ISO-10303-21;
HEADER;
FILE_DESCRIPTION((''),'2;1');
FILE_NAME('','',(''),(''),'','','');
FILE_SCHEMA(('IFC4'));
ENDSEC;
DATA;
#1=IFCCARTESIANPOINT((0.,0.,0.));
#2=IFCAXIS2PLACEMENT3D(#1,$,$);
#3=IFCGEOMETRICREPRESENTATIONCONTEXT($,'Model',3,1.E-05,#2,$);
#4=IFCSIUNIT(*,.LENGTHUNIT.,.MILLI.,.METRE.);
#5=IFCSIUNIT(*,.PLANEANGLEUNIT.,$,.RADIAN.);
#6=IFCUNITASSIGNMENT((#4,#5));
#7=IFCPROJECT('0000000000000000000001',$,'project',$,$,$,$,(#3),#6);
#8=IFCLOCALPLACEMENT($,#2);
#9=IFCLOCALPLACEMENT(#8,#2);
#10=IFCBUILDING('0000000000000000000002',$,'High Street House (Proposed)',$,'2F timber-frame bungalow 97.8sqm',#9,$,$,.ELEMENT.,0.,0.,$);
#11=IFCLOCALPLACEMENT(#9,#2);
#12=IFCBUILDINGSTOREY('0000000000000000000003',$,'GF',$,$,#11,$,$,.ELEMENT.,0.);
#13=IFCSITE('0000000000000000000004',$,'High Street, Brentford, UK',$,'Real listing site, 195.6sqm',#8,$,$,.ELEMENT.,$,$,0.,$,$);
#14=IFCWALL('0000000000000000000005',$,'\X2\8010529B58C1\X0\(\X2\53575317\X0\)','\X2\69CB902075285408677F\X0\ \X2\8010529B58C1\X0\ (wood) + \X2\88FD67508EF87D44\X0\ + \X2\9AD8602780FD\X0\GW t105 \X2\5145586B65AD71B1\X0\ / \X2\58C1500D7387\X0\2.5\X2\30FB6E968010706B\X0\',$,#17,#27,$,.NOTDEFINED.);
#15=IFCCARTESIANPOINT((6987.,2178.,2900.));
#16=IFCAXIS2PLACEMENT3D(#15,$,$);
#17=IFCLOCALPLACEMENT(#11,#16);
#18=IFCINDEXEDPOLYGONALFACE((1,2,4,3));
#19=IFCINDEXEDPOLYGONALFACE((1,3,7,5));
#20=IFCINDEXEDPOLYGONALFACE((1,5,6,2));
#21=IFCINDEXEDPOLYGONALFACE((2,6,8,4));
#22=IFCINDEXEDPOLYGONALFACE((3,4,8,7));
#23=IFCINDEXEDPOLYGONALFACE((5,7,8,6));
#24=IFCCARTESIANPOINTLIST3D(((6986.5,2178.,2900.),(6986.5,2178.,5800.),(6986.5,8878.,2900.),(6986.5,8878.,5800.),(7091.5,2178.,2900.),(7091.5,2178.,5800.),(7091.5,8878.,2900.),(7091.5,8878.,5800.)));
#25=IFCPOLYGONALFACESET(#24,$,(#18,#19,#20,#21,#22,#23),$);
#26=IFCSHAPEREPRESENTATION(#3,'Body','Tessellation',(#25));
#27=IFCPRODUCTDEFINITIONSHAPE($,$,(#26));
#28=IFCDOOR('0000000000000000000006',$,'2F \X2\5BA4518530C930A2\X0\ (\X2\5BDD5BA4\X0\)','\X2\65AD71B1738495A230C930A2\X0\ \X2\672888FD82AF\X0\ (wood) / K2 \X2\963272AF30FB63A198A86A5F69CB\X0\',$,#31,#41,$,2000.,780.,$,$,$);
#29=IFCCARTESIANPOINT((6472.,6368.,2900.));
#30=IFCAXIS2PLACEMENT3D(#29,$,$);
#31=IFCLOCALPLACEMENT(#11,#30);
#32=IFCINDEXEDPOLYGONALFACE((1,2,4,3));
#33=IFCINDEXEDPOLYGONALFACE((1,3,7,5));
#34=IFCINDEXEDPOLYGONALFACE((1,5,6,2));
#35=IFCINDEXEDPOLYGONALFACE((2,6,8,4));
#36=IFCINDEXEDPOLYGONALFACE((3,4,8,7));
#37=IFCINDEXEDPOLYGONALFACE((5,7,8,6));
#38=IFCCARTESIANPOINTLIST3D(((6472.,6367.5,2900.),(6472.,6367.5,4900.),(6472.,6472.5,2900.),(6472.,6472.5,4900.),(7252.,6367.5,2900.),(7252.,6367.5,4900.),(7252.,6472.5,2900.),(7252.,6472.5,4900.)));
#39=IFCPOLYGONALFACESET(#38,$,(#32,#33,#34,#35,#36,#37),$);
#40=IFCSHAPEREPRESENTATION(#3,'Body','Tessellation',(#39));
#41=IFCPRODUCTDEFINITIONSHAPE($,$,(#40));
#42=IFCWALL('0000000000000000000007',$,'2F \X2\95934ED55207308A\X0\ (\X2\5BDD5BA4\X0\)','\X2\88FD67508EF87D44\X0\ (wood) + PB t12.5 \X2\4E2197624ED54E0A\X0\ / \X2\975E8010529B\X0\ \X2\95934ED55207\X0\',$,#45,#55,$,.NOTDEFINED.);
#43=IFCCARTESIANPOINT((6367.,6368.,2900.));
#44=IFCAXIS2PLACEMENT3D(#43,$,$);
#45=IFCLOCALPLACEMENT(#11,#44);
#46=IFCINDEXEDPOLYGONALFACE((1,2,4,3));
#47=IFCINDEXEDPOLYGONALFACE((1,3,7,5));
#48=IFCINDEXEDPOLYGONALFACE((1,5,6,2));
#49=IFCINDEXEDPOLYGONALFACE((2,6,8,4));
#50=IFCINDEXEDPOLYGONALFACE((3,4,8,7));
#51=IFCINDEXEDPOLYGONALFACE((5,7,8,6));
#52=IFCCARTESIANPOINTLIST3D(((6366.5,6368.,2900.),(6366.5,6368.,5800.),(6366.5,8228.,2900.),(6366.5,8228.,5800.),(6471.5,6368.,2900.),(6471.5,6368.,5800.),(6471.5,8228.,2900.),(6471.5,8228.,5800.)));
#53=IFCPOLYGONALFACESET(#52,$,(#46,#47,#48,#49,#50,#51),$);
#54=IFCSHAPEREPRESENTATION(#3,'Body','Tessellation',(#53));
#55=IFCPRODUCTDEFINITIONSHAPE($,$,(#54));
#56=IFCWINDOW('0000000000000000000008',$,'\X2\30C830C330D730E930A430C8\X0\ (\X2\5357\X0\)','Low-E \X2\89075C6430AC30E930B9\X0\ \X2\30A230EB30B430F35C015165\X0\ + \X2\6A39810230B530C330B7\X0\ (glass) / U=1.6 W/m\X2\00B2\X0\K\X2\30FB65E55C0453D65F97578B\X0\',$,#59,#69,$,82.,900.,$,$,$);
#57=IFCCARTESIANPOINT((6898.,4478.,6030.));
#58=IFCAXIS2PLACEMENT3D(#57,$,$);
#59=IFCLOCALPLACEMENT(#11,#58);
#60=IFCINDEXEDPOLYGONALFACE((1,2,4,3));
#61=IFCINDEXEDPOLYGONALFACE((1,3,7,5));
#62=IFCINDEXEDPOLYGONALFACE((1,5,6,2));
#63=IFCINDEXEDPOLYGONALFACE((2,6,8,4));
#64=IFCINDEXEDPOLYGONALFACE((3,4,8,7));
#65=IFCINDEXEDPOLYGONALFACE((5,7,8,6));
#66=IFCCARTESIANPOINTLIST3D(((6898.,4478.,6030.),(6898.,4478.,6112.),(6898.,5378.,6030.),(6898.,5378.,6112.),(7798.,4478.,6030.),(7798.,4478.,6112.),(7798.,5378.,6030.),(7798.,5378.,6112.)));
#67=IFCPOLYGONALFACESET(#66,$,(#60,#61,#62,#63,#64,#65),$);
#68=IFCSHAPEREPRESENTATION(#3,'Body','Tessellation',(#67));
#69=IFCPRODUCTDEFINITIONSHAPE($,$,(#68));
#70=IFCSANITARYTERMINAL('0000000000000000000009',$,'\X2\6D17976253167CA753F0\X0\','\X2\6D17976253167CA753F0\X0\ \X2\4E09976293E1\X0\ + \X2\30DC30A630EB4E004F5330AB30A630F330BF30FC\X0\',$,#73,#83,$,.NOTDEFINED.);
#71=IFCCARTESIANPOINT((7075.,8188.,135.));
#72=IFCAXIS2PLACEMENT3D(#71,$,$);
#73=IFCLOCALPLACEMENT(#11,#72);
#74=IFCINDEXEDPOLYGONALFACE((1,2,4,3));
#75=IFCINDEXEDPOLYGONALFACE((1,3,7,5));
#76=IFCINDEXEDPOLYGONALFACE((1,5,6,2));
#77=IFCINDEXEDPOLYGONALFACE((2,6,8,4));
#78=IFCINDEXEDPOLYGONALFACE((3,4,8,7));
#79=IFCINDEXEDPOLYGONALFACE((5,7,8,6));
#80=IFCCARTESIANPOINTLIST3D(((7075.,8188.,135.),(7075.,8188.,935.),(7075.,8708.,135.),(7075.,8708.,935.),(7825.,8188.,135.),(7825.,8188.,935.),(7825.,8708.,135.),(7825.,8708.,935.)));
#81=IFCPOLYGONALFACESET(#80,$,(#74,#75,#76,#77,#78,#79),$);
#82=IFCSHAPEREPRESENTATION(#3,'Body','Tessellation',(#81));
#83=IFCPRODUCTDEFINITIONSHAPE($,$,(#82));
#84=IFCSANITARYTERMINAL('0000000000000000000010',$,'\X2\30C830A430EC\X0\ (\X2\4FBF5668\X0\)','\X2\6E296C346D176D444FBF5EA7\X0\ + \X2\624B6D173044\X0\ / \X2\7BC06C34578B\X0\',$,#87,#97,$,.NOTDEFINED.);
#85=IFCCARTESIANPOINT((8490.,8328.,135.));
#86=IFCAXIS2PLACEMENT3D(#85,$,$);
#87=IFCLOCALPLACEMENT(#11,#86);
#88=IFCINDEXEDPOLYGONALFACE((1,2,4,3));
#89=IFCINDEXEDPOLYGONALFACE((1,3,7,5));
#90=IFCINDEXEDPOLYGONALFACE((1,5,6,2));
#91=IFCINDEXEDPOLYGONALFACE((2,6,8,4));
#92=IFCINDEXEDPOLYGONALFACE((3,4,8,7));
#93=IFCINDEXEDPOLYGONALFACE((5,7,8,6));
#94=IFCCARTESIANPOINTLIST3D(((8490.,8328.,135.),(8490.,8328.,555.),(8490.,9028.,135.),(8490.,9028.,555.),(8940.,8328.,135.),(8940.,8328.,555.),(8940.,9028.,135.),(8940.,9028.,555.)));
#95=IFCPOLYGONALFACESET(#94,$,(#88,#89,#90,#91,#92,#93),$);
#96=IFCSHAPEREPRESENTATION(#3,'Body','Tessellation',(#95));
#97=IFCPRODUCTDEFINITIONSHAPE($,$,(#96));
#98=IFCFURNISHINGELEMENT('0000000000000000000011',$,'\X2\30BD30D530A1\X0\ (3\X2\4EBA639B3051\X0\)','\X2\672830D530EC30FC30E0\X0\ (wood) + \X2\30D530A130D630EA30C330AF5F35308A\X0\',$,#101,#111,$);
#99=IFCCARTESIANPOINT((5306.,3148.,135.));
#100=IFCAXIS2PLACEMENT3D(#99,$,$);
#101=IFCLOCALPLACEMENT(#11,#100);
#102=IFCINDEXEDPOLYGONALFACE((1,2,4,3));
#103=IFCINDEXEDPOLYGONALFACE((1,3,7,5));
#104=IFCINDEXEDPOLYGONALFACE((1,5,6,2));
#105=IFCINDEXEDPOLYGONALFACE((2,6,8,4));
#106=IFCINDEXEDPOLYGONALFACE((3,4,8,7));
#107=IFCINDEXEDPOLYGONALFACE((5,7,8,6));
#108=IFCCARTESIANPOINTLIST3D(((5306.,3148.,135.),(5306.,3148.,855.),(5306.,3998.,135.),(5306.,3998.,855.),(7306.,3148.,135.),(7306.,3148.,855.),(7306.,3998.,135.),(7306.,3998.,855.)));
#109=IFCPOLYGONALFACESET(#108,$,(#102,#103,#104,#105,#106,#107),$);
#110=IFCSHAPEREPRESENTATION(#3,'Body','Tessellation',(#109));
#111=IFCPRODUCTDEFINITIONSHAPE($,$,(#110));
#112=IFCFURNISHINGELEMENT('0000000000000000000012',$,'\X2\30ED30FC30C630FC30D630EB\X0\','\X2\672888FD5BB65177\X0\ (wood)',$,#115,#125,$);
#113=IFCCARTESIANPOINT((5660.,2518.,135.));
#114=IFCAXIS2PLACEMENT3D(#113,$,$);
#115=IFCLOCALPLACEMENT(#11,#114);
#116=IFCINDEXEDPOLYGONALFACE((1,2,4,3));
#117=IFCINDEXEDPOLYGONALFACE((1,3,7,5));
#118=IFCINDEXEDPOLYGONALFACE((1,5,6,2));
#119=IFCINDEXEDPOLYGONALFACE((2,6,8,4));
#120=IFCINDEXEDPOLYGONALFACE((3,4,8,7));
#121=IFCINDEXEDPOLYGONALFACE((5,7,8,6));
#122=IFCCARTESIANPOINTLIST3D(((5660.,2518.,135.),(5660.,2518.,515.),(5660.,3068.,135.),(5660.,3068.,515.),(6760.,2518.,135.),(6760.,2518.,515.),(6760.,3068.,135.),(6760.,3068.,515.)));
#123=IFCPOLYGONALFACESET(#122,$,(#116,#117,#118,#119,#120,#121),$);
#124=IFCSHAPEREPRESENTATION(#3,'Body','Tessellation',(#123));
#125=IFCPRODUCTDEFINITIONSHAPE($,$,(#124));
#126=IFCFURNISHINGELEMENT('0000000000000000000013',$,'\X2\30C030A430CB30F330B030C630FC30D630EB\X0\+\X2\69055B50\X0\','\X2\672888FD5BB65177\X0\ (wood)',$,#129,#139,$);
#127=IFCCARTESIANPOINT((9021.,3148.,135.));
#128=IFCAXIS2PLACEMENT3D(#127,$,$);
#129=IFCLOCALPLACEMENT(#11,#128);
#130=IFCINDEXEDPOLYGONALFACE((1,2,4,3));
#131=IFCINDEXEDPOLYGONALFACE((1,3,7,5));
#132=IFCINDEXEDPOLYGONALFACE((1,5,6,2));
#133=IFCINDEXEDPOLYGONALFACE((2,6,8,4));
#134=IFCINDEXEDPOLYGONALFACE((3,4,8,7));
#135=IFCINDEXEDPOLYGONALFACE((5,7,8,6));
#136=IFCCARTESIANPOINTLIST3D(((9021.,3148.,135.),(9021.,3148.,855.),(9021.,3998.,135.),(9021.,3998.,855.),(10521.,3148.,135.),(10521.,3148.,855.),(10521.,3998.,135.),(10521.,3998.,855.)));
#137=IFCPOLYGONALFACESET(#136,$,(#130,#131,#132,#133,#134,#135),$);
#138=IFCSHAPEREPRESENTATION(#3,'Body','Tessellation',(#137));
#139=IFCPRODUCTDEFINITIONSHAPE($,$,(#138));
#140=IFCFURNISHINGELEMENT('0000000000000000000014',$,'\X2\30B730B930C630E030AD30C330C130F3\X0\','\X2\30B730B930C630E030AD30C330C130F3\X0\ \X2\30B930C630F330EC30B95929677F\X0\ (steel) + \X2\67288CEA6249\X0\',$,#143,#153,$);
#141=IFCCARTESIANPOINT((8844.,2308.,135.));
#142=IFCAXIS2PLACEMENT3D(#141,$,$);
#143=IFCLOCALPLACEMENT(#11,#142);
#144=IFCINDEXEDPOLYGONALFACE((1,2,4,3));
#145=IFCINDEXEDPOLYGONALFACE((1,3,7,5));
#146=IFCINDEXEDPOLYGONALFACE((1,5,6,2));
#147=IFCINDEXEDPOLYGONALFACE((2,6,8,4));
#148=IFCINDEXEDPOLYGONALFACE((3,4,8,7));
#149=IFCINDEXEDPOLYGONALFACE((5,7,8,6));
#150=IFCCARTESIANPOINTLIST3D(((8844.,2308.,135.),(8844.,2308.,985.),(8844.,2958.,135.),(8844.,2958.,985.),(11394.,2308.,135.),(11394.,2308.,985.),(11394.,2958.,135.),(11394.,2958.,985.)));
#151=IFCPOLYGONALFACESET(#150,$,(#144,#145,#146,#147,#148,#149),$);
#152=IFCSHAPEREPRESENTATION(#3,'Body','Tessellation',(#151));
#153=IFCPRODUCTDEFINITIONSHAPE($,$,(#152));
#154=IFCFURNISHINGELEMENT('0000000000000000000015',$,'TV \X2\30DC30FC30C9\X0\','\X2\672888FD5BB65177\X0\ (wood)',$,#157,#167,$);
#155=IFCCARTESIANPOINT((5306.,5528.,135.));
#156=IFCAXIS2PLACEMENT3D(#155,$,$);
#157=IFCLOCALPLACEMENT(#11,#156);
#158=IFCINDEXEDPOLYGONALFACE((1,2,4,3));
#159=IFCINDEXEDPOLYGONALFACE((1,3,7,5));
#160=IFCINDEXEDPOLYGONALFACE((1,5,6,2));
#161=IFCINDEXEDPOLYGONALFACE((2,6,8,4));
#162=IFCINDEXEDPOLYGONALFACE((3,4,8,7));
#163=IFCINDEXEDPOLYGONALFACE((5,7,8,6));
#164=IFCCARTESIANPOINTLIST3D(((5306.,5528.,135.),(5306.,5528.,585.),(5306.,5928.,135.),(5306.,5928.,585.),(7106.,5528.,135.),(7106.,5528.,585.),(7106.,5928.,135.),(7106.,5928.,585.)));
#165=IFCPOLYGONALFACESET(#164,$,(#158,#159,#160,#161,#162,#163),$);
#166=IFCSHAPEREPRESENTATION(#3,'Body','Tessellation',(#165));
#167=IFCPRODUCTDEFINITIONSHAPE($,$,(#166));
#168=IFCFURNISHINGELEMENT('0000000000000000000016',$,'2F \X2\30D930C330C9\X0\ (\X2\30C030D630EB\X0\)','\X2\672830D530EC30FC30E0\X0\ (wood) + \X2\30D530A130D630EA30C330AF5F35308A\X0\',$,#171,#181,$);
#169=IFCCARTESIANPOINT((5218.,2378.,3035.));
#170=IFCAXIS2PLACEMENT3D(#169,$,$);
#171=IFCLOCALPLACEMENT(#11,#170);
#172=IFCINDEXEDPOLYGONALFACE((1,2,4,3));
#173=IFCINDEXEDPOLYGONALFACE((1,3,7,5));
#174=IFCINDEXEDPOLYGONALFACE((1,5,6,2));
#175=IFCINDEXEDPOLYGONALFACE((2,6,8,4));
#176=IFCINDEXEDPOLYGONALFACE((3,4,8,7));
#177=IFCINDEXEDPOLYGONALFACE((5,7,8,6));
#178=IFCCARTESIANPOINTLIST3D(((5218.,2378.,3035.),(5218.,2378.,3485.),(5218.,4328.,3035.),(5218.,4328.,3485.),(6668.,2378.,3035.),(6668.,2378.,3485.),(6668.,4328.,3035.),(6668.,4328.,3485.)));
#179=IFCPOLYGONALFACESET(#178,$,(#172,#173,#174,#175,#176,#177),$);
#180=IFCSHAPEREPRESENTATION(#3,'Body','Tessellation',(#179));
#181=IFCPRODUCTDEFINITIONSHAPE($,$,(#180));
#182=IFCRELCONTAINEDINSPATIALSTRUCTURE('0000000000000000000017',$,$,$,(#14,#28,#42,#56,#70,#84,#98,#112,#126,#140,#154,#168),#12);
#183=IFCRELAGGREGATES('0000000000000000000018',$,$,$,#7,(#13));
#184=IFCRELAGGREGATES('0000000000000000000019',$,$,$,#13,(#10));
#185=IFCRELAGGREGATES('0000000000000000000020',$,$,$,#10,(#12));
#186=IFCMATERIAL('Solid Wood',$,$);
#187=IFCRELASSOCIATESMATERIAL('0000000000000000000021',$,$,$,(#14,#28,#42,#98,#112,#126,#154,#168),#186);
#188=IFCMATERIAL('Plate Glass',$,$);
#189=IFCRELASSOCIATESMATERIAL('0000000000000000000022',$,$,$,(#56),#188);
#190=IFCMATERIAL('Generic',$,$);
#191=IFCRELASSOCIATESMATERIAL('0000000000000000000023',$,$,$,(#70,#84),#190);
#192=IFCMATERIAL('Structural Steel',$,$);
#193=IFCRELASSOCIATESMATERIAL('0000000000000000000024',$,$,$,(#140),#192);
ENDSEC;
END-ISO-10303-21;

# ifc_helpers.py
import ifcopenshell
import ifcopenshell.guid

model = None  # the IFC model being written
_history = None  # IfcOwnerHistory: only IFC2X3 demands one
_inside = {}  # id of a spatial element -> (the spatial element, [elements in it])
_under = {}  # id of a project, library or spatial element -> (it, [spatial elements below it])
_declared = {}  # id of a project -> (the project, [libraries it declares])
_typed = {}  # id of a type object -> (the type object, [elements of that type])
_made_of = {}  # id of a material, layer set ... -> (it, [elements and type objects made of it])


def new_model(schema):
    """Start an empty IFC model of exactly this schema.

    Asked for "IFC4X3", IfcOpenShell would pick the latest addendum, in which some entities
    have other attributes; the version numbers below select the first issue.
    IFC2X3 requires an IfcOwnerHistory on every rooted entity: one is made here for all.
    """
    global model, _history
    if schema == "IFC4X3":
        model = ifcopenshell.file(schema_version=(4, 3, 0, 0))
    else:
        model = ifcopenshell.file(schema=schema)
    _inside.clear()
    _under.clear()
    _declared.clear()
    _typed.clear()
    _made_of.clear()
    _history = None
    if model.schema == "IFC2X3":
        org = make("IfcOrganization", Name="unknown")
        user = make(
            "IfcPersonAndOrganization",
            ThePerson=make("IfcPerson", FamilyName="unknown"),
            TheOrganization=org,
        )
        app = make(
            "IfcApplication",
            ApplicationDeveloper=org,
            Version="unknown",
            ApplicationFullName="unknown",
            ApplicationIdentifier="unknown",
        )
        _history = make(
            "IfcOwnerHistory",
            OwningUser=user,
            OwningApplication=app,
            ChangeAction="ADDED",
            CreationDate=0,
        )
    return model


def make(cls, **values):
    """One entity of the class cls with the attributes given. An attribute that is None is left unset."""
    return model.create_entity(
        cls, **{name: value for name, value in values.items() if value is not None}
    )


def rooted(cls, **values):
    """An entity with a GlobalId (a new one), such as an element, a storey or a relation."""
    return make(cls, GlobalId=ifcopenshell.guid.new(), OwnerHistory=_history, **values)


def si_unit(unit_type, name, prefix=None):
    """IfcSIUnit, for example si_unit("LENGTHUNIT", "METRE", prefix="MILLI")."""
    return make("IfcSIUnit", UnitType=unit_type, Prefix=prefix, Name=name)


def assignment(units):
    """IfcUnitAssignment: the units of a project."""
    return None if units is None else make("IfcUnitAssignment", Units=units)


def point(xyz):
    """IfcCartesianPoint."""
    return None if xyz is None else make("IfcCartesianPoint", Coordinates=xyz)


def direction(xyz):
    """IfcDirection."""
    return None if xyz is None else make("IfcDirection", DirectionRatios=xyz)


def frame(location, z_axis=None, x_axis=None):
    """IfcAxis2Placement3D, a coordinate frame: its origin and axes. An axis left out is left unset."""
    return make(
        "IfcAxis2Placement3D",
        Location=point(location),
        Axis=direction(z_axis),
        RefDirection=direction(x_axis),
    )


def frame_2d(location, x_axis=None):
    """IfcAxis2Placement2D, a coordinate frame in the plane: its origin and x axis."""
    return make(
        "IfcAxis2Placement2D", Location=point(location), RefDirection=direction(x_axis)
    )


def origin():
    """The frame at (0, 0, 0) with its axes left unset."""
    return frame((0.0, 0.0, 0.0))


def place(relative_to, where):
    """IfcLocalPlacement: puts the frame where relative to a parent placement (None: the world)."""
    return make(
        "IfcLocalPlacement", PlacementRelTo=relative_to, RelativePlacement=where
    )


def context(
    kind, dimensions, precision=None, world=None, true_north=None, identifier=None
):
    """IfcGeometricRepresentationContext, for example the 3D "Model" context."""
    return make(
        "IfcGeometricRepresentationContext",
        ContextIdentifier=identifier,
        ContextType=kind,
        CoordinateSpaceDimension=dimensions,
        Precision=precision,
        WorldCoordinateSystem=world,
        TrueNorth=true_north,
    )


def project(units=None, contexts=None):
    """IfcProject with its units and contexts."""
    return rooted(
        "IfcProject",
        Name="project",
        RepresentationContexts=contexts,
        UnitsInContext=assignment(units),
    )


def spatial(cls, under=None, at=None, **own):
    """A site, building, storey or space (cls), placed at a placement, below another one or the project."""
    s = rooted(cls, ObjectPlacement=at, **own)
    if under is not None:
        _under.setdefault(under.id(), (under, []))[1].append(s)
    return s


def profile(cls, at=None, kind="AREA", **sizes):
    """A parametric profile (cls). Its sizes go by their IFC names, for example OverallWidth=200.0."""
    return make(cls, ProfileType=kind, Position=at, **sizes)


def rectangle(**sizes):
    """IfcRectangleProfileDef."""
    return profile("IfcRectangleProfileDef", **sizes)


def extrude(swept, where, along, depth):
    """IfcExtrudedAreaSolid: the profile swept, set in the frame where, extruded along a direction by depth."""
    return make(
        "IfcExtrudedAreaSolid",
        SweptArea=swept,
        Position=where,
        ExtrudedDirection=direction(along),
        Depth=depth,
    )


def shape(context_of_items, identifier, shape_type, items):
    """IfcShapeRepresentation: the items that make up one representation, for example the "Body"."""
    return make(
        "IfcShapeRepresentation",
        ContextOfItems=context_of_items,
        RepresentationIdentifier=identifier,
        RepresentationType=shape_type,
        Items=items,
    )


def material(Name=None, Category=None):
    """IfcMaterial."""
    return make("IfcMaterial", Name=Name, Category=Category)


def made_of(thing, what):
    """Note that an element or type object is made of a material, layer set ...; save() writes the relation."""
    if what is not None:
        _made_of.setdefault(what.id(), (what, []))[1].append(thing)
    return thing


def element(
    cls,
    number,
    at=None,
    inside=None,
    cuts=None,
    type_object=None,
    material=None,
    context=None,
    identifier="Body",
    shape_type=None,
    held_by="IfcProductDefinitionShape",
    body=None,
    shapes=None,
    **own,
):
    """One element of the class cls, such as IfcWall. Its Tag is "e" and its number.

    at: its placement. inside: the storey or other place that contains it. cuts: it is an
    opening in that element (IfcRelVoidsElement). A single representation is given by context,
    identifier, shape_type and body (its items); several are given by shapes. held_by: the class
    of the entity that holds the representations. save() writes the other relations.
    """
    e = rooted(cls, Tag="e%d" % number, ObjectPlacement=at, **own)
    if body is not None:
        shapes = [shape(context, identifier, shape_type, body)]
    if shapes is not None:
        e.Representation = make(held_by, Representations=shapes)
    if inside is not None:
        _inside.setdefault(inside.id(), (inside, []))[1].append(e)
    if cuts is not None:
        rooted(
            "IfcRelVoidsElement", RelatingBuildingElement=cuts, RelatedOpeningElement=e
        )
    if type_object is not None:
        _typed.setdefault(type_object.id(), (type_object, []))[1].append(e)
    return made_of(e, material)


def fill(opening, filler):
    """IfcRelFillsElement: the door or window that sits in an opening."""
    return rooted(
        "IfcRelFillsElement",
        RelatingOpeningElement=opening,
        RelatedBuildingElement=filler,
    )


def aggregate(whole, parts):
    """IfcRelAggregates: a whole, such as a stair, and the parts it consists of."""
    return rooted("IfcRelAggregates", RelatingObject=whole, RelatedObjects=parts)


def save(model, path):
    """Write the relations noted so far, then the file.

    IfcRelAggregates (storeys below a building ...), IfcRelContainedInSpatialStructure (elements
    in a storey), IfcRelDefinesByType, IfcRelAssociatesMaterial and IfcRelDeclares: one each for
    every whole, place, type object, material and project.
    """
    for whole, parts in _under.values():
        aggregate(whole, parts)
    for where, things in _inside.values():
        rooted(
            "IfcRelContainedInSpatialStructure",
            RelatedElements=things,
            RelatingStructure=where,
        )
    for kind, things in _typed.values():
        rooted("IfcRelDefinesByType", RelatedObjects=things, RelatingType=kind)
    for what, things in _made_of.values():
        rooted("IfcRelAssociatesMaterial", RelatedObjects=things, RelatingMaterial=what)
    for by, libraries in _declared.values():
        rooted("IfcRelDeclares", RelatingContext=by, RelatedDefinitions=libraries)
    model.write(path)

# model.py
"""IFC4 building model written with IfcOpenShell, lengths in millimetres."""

from ifc_helpers import new_model, si_unit, frame, frame_2d, origin, place, context, project, spatial, rectangle, extrude, material, element, fill, save


model = new_model("IFC4")

# Units and contexts
model_context = context("Model", 3, precision=1e-05, world=origin())
ifc_project = project(units=[si_unit("LENGTHUNIT", "METRE", prefix="MILLI"), si_unit("PLANEANGLEUNIT", "RADIAN")], contexts=[model_context])

# Site, building, storey
site_placement = place(None, origin())
site = spatial("IfcSite", under=ifc_project, at=site_placement, Name="High Street, Brentford, UK", ObjectType="Real listing site, 195.6sqm", CompositionType="ELEMENT", RefElevation=0.0)
building_placement = place(site_placement, origin())
building = spatial("IfcBuilding", under=site, at=building_placement, Name="High Street House (Proposed)", ObjectType="2F timber-frame bungalow 97.8sqm", CompositionType="ELEMENT", ElevationOfRefHeight=0.0, ElevationOfTerrain=0.0)
storey_placement = place(building_placement, origin())
storey = spatial("IfcBuildingStorey", under=building, at=storey_placement, Name="GF", CompositionType="ELEMENT", Elevation=0.0)

# Shared definitions
ifc_material_1 = material(Name="Solid Wood")

# Wall, opening, door
wall_1_placement = place(storey_placement, frame((6987.0, 2178.0, 2900.0)))
wall_1 = element("IfcWall", 1, at=wall_1_placement, inside=storey, material=ifc_material_1, Name="耐力壁(南北)", Description="構造用合板 耐力壁 (wood) + 製材軸組 + 高性能GW t105 充填断熱 / 壁倍率2.5・準耐火", PredefinedType="NOTDEFINED", context=model_context, shape_type="SweptSolid", body=[
    extrude(rectangle(XDim=105.0, YDim=6700.0, at=frame_2d((52.0, 3350.0))), frame((6987.0, 2178.0, 2900.0)), (0.0, 0.0, 1.0), 2900.0),
])
opening_1_placement = place(storey_placement, frame((6472.0, 6368.0, 2900.0)))
opening_1 = element("IfcOpeningElement", 2, at=opening_1_placement, cuts=wall_1, PredefinedType="NOTDEFINED", context=model_context, shape_type="SweptSolid", body=[
    extrude(rectangle(XDim=780.0, YDim=105.0, at=frame_2d((390.0, 52.0))), frame((6472.0, 6368.0, 2900.0)), (0.0, 0.0, 1.0), 2000.0),
])
door_1_placement = place(storey_placement, frame((6472.0, 6368.0, 2900.0)))
door_1 = element("IfcDoor", 3, at=door_1_placement, inside=storey, material=ifc_material_1, Name="2F 室内ドア (寝室)", Description="断熱玄関ドア 木製芯 (wood) / K2 防犯・採風機構", OverallHeight=2000.0, OverallWidth=780.0, context=model_context, shape_type="SweptSolid", body=[
    extrude(rectangle(XDim=780.0, YDim=105.0, at=frame_2d((390.0, 52.0))), frame((6472.0, 6368.0, 2900.0)), (0.0, 0.0, 1.0), 2000.0),
])
fill(opening_1, door_1)

# Wall
wall_2_placement = place(storey_placement, frame((6367.0, 6368.0, 2900.0)))
element("IfcWall", 4, at=wall_2_placement, inside=storey, material=ifc_material_1, Name="2F 間仕切り (寝室)", Description="製材軸組 (wood) + PB t12.5 両面仕上 / 非耐力 間仕切", PredefinedType="NOTDEFINED", context=model_context, shape_type="SweptSolid", body=[
    extrude(rectangle(XDim=105.0, YDim=1860.0, at=frame_2d((52.0, 930.0))), frame((6367.0, 6368.0, 2900.0)), (0.0, 0.0, 1.0), 2900.0),
])

# Window
ifc_material_2 = material(Name="Plate Glass")
window_placement = place(storey_placement, frame((6898.0, 4478.0, 6030.0)))
element("IfcWindow", 5, at=window_placement, inside=storey, material=ifc_material_2, Name="トップライト (南)", Description="Low-E 複層ガラス アルゴン封入 + 樹脂サッシ (glass) / U=1.6 W/m²K・日射取得型", OverallHeight=82.0, OverallWidth=900.0, context=model_context, shape_type="SweptSolid", body=[
    extrude(rectangle(XDim=900.0, YDim=900.0, at=frame_2d((450.0, 450.0))), frame((6898.0, 4478.0, 6030.0)), (0.0, 0.0, 1.0), 82.0),
])

# Sanitary terminals
ifc_material_3 = material(Name="Generic")
sanitary_terminal_1_placement = place(storey_placement, frame((7075.0, 8188.0, 135.0)))
element("IfcSanitaryTerminal", 6, at=sanitary_terminal_1_placement, inside=storey, material=ifc_material_3, Name="洗面化粧台", Description="洗面化粧台 三面鏡 + ボウル一体カウンター", PredefinedType="NOTDEFINED", context=model_context, shape_type="SweptSolid", body=[
    extrude(rectangle(XDim=750.0, YDim=520.0, at=frame_2d((375.0, 260.0))), frame((7075.0, 8188.0, 135.0)), (0.0, 0.0, 1.0), 800.0),
])
sanitary_terminal_2_placement = place(storey_placement, frame((8490.0, 8328.0, 135.0)))
element("IfcSanitaryTerminal", 7, at=sanitary_terminal_2_placement, inside=storey, material=ifc_material_3, Name="トイレ (便器)", Description="温水洗浄便座 + 手洗い / 節水型", PredefinedType="NOTDEFINED", context=model_context, shape_type="SweptSolid", body=[
    extrude(rectangle(XDim=450.0, YDim=700.0, at=frame_2d((225.0, 350.0))), frame((8490.0, 8328.0, 135.0)), (0.0, 0.0, 1.0), 420.0),
])

# Furnishing elements
furnishing_1_placement = place(storey_placement, frame((5306.0, 3148.0, 135.0)))
element("IfcFurnishingElement", 8, at=furnishing_1_placement, inside=storey, material=ifc_material_1, Name="ソファ (3人掛け)", Description="木フレーム (wood) + ファブリック張り", context=model_context, shape_type="SweptSolid", body=[
    extrude(rectangle(XDim=2000.0, YDim=850.0, at=frame_2d((1000.0, 425.0))), frame((5306.0, 3148.0, 135.0)), (0.0, 0.0, 1.0), 720.0),
])
furnishing_2_placement = place(storey_placement, frame((5660.0, 2518.0, 135.0)))
element("IfcFurnishingElement", 9, at=furnishing_2_placement, inside=storey, material=ifc_material_1, Name="ローテーブル", Description="木製家具 (wood)", context=model_context, shape_type="SweptSolid", body=[
    extrude(rectangle(XDim=1100.0, YDim=550.0, at=frame_2d((550.0, 275.0))), frame((5660.0, 2518.0, 135.0)), (0.0, 0.0, 1.0), 380.0),
])
furnishing_3_placement = place(storey_placement, frame((9021.0, 3148.0, 135.0)))
element("IfcFurnishingElement", 10, at=furnishing_3_placement, inside=storey, material=ifc_material_1, Name="ダイニングテーブル+椅子", Description="木製家具 (wood)", context=model_context, shape_type="SweptSolid", body=[
    extrude(rectangle(XDim=1500.0, YDim=850.0, at=frame_2d((750.0, 425.0))), frame((9021.0, 3148.0, 135.0)), (0.0, 0.0, 1.0), 720.0),
])
ifc_material_4 = material(Name="Structural Steel")
furnishing_4_placement = place(storey_placement, frame((8844.0, 2308.0, 135.0)))
element("IfcFurnishingElement", 11, at=furnishing_4_placement, inside=storey, material=ifc_material_4, Name="システムキッチン", Description="システムキッチン ステンレス天板 (steel) + 木質扉", context=model_context, shape_type="SweptSolid", body=[
    extrude(rectangle(XDim=2550.0, YDim=650.0, at=frame_2d((1275.0, 325.0))), frame((8844.0, 2308.0, 135.0)), (0.0, 0.0, 1.0), 850.0),
])
furnishing_5_placement = place(storey_placement, frame((5306.0, 5528.0, 135.0)))
element("IfcFurnishingElement", 12, at=furnishing_5_placement, inside=storey, material=ifc_material_1, Name="TV ボード", Description="木製家具 (wood)", context=model_context, shape_type="SweptSolid", body=[
    extrude(rectangle(XDim=1800.0, YDim=400.0, at=frame_2d((900.0, 200.0))), frame((5306.0, 5528.0, 135.0)), (0.0, 0.0, 1.0), 450.0),
])
furnishing_6_placement = place(storey_placement, frame((5218.0, 2378.0, 3035.0)))
element("IfcFurnishingElement", 13, at=furnishing_6_placement, inside=storey, material=ifc_material_1, Name="2F ベッド (ダブル)", Description="木フレーム (wood) + ファブリック張り", context=model_context, shape_type="SweptSolid", body=[
    extrude(rectangle(XDim=1450.0, YDim=1950.0, at=frame_2d((725.0, 975.0))), frame((5218.0, 2378.0, 3035.0)), (0.0, 0.0, 1.0), 450.0),
])

save(model, "model.ifc")
